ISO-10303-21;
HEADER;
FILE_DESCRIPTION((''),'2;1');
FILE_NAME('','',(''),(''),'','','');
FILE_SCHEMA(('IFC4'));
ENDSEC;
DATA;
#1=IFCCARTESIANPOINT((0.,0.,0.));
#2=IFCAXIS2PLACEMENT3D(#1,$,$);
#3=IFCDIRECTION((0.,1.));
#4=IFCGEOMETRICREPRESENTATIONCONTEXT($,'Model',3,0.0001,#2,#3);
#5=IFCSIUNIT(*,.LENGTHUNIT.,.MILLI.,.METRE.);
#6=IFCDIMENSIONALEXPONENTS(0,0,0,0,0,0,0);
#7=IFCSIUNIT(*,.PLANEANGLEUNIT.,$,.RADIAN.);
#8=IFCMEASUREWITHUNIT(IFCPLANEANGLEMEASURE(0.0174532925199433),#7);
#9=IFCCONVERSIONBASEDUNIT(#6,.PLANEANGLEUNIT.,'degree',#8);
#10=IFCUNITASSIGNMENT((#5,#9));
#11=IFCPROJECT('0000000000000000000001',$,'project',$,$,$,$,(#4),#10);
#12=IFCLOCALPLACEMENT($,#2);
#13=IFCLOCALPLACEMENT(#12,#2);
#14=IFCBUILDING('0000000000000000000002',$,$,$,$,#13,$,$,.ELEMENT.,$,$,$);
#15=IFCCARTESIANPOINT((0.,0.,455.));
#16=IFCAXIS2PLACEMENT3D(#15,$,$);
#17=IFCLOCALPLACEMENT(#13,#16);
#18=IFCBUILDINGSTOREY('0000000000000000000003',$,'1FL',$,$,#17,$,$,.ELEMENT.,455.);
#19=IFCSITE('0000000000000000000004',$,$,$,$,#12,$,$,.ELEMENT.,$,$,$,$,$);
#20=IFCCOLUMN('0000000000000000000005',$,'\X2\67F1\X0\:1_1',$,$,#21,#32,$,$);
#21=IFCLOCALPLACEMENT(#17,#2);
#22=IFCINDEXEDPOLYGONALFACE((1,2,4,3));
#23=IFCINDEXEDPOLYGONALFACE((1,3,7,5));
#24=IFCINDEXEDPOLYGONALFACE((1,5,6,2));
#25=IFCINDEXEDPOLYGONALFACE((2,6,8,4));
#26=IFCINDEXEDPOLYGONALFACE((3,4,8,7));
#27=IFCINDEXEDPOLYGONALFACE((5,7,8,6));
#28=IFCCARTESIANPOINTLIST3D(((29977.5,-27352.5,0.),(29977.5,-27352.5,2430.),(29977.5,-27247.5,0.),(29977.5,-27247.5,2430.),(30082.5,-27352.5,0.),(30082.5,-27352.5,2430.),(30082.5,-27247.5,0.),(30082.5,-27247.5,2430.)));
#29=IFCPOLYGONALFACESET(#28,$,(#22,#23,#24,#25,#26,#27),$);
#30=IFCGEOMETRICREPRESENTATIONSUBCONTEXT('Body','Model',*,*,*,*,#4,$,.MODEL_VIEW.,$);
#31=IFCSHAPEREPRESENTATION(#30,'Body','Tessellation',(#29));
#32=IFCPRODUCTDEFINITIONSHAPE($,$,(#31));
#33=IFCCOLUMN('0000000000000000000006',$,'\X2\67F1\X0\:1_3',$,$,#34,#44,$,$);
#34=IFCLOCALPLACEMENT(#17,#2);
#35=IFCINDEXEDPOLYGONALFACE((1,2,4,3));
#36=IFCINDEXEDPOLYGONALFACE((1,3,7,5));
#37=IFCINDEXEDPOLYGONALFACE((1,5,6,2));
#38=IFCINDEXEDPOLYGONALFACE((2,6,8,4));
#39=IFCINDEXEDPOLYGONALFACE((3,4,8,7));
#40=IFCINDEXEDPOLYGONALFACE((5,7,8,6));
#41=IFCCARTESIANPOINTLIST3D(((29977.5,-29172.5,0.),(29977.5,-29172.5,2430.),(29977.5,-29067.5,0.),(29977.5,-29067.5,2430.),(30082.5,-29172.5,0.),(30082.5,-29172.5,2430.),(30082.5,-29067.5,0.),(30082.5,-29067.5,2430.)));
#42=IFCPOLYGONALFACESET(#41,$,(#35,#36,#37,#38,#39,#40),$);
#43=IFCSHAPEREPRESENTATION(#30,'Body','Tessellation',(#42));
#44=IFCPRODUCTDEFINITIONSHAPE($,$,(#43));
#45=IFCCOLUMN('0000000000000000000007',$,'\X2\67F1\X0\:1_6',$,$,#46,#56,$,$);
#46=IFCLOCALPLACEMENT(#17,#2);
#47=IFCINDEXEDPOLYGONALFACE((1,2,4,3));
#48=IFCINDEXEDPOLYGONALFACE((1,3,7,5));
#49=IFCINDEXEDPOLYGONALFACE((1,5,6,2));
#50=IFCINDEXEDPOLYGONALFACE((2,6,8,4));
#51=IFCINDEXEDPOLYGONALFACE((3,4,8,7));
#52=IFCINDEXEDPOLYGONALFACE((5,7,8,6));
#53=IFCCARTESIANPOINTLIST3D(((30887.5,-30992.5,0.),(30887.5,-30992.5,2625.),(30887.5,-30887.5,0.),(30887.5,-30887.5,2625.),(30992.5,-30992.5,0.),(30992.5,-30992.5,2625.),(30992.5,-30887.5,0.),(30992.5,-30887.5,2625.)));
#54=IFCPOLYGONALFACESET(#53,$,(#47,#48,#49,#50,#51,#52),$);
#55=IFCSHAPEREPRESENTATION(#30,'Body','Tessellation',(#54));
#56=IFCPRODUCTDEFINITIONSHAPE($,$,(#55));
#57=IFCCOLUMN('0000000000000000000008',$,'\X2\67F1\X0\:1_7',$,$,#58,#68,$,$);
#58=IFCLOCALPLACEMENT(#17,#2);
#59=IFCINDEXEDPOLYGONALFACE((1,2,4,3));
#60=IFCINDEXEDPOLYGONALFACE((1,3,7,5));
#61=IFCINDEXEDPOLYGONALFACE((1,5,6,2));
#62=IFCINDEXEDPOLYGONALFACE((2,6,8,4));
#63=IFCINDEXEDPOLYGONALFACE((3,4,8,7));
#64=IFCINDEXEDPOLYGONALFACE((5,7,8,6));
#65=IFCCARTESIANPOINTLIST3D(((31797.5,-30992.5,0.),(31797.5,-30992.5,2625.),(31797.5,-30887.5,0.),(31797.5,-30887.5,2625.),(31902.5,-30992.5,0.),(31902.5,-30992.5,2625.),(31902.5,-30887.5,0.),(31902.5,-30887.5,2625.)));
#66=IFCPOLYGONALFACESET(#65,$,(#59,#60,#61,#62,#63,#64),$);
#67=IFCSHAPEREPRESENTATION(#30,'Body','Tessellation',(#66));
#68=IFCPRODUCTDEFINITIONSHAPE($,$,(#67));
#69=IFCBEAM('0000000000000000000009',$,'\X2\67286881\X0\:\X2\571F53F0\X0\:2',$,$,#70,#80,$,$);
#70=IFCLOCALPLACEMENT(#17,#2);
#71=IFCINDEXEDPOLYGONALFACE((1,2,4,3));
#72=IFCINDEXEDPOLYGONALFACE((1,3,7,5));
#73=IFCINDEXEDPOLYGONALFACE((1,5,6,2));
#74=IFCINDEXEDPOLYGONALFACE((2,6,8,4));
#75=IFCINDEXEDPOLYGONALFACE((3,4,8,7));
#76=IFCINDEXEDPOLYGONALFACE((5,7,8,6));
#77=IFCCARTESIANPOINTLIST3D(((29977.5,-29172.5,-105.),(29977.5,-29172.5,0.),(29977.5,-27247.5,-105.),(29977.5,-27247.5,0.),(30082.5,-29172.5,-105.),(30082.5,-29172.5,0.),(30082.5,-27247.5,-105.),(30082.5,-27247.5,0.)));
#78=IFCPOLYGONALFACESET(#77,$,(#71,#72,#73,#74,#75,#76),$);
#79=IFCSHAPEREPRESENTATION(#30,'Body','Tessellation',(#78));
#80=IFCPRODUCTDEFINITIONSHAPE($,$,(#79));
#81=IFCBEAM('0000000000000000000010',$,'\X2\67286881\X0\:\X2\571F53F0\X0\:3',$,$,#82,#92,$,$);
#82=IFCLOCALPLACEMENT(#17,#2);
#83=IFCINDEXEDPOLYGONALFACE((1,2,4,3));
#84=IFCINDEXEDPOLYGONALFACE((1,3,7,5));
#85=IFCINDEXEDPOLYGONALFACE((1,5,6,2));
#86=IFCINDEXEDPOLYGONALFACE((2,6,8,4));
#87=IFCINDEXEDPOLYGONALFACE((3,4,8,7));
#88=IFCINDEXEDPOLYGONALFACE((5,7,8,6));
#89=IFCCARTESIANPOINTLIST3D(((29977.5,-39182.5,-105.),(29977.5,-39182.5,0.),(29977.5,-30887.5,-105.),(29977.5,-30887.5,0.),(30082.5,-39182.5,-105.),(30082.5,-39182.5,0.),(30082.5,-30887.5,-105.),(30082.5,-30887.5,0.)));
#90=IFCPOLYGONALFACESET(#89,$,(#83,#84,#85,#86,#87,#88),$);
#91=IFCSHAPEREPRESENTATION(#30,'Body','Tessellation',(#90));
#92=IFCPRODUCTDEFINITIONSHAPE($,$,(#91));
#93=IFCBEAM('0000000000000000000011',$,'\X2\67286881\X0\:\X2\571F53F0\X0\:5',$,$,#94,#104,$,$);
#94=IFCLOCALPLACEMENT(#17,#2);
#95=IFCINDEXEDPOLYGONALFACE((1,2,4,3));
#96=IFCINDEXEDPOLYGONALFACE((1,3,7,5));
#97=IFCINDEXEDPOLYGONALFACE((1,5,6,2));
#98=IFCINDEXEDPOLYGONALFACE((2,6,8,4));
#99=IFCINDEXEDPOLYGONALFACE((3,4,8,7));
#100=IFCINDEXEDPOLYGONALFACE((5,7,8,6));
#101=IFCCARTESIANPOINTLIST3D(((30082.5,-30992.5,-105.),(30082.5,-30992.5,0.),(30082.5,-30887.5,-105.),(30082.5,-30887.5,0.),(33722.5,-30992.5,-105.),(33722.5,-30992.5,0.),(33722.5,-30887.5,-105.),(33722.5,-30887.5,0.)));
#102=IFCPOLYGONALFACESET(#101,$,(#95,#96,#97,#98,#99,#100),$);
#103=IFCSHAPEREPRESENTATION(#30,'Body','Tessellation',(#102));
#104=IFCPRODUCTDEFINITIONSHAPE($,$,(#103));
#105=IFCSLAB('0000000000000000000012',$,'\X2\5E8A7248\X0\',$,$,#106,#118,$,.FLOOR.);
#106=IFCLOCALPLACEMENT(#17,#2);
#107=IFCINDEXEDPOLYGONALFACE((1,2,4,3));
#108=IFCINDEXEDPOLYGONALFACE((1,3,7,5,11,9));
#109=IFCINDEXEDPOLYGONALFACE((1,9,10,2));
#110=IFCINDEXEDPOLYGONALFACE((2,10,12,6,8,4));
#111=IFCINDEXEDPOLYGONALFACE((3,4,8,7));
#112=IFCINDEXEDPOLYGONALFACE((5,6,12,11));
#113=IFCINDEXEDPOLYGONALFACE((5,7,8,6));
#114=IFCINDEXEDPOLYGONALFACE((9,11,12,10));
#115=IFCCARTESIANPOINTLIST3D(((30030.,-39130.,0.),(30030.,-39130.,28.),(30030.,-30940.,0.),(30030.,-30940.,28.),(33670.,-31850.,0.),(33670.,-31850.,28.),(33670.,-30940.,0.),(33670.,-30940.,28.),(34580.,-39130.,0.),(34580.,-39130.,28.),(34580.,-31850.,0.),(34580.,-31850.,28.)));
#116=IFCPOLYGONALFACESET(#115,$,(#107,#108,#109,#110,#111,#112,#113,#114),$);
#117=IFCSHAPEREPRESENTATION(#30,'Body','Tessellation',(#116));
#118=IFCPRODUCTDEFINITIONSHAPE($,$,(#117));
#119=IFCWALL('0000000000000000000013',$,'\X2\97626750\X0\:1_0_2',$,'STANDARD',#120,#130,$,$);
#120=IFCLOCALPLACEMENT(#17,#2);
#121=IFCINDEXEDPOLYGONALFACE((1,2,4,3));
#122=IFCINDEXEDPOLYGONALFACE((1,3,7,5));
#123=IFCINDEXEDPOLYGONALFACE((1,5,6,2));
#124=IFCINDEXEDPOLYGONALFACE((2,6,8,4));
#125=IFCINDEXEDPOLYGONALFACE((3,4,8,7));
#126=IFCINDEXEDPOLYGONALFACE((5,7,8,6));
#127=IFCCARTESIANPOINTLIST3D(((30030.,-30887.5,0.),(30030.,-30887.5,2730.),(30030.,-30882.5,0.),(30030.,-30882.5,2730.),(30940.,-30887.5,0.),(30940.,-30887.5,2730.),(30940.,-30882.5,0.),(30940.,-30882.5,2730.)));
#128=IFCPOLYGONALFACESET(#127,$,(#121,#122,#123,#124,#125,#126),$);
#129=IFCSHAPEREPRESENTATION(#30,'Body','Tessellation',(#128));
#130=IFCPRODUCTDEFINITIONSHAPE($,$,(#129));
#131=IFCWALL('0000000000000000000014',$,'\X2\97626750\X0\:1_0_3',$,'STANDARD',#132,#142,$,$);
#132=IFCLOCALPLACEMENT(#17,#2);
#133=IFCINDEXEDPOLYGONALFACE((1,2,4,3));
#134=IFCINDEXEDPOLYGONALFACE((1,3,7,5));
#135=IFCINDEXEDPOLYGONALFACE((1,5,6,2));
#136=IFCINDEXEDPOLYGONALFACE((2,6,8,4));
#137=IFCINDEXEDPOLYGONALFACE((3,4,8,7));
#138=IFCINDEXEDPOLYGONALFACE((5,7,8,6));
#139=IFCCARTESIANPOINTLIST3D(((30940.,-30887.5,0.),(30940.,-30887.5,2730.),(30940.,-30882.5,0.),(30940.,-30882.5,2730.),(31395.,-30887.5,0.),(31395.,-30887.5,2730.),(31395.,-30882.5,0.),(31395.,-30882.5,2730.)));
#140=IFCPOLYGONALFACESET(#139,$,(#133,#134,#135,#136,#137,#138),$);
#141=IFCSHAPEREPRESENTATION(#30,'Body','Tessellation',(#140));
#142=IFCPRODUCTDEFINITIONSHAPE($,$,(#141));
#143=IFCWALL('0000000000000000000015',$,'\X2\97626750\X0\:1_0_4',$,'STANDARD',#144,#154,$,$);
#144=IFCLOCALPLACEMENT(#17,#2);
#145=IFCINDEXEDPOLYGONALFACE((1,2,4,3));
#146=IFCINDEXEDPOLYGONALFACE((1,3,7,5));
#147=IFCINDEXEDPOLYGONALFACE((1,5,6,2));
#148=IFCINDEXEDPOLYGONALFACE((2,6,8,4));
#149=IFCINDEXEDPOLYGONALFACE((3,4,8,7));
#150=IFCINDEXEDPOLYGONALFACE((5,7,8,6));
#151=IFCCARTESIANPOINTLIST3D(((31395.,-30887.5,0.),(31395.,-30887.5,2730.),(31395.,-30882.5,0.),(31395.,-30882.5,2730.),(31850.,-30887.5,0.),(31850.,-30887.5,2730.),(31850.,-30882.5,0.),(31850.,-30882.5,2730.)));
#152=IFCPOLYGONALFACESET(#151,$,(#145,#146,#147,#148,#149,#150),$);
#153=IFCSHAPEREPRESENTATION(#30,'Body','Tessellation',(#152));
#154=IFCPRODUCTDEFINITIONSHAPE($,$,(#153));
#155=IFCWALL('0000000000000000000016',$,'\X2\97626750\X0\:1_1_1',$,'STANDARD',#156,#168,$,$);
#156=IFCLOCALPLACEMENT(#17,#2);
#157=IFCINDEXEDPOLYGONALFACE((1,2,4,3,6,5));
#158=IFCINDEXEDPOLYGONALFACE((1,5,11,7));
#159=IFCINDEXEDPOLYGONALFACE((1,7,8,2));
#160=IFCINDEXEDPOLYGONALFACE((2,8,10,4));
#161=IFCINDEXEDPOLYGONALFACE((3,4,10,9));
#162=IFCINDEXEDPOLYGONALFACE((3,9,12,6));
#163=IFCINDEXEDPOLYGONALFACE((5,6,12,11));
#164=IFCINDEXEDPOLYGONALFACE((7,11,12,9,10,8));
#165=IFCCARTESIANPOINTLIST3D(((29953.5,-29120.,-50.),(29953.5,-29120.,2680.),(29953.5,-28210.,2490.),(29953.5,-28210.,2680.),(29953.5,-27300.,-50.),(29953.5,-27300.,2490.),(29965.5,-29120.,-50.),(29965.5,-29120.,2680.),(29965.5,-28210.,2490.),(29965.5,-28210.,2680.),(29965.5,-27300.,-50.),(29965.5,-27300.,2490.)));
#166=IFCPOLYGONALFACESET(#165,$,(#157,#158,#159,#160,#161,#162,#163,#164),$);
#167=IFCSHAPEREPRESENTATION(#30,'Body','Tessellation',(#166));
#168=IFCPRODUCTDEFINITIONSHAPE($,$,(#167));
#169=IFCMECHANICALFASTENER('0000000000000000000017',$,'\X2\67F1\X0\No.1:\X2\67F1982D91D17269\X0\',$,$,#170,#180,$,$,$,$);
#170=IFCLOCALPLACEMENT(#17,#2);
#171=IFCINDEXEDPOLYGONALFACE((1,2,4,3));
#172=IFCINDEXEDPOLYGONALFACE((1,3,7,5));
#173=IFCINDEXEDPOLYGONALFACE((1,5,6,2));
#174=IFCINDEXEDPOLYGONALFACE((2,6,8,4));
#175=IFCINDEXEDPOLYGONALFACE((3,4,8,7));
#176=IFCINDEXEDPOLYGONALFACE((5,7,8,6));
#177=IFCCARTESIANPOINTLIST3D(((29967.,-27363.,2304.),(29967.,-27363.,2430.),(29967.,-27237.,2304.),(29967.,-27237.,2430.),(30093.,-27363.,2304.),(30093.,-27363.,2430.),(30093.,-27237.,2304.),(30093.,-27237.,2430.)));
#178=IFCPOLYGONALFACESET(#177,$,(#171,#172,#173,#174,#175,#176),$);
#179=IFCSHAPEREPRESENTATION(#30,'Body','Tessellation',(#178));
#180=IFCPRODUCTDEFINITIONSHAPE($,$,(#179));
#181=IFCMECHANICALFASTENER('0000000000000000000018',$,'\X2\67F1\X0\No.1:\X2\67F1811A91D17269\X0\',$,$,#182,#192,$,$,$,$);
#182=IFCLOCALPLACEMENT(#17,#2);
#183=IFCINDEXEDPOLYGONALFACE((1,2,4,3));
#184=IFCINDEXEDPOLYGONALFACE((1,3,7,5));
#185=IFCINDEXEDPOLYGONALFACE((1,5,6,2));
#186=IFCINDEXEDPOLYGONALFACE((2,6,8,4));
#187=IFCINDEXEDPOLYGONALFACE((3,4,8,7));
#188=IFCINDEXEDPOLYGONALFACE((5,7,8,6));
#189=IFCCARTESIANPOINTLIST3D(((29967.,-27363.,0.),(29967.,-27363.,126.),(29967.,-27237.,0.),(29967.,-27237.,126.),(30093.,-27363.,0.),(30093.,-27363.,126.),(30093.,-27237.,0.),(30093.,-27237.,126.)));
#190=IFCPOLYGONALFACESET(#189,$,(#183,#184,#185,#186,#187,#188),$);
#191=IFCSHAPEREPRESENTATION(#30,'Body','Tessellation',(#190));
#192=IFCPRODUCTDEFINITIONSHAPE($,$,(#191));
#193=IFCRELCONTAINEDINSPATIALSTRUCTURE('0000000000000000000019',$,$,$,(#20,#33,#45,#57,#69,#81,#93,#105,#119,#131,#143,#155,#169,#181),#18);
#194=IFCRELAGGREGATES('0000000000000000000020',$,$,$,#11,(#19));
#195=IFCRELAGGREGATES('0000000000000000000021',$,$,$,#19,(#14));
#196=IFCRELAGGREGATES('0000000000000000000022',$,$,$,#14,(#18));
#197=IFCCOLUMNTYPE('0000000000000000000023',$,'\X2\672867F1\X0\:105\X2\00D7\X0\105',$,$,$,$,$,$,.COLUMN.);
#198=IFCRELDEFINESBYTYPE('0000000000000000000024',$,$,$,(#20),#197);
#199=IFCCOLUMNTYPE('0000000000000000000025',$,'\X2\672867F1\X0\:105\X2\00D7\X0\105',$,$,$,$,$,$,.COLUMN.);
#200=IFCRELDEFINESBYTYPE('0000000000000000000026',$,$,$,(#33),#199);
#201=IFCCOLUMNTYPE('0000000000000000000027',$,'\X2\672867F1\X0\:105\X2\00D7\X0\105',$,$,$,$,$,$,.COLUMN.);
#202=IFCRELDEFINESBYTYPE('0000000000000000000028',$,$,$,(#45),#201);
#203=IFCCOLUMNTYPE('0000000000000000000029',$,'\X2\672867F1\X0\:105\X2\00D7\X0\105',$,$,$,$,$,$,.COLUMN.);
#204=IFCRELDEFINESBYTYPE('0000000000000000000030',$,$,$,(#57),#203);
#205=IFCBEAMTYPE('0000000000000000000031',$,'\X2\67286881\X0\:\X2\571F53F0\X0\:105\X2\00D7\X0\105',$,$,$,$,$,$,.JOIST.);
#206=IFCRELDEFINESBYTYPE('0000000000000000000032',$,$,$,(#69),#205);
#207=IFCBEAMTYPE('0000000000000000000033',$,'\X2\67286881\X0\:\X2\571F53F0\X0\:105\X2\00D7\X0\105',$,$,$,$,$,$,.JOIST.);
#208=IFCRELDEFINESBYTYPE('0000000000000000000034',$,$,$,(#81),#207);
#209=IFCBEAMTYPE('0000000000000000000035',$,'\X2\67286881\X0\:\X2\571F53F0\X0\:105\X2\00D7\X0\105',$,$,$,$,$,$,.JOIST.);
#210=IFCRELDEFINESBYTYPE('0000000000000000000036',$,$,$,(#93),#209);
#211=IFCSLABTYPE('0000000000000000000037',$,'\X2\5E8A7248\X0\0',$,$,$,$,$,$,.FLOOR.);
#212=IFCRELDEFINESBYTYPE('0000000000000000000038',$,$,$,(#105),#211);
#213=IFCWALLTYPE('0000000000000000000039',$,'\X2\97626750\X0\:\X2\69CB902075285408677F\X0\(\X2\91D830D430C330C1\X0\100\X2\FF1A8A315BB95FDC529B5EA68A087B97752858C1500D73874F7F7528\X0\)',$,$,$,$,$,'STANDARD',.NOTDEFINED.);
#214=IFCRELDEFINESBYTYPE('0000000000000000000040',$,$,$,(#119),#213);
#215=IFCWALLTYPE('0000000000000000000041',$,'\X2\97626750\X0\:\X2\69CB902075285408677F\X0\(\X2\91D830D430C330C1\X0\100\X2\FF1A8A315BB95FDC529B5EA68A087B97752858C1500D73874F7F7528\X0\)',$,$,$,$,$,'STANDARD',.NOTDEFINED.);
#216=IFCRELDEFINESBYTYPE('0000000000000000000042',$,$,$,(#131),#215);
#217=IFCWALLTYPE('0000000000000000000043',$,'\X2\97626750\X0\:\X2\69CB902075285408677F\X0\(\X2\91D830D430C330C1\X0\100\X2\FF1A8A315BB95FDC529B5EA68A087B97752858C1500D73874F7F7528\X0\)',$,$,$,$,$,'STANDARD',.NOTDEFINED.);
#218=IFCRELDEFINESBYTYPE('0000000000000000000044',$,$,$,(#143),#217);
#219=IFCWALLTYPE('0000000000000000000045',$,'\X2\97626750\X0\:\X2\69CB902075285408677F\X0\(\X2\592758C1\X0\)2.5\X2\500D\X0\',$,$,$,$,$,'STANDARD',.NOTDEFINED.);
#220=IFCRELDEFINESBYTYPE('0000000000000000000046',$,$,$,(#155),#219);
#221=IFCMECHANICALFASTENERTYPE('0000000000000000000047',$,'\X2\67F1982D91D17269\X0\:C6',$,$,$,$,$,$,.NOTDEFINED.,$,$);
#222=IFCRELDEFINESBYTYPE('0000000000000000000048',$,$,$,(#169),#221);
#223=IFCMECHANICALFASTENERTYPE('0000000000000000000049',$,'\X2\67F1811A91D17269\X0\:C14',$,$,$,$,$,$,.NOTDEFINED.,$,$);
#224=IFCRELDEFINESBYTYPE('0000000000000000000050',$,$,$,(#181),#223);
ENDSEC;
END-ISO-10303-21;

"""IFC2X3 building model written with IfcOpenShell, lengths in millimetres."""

from ifc_helpers import new_model, entity, si_unit, converted_unit, direction, frame, origin, origin_with_axes, origin_2d, place, context, subcontext, project, spatial, polyline, rectangle, outline, extrude, type_object, element, save


model = new_model("IFC2X3")

# Units and contexts
model_context = context("Model", 3, precision=0.0001, world=origin(), true_north=direction((0.0, 1.0)))
body_context = subcontext(model_context, "Body", "Model", "MODEL_VIEW")
ifc_project = project(units=[si_unit("LENGTHUNIT", "METRE", prefix="MILLI"), converted_unit("PLANEANGLEUNIT", "degree", entity("IfcPlaneAngleMeasure", 0.0174532925199433), si_unit("PLANEANGLEUNIT", "RADIAN"), dimensions=[0, 0, 0, 0, 0, 0, 0])], contexts=[model_context])

# Site, building, storey
site_placement = place(None, origin())
site = spatial("IfcSite", under=ifc_project, at=site_placement, CompositionType="ELEMENT")
building_placement = place(site_placement, origin())
building = spatial("IfcBuilding", under=site, at=building_placement, CompositionType="ELEMENT")
storey_placement = place(building_placement, frame((0.0, 0.0, 455.0)))
storey = spatial("IfcBuildingStorey", under=building, at=storey_placement, Name="1FL", CompositionType="ELEMENT", Elevation=455.0)

# Columns
column_type_1 = type_object("IfcColumnType", Name="木柱:105×105", PredefinedType="COLUMN")
column_1_placement = place(storey_placement, frame((30030.0, -27300.0, 0.0)))
element("IfcColumn", 1, at=column_1_placement, inside=storey, type_object=column_type_1, Name="柱:1_1", context=body_context, shape_type="SweptSolid", body=[
    extrude(rectangle(XDim=105.0, YDim=105.0, at=origin_2d()), origin_with_axes(), (0.0, 0.0, 1.0), 2430.0),
])
column_type_2 = type_object("IfcColumnType", Name="木柱:105×105", PredefinedType="COLUMN")
column_2_placement = place(storey_placement, frame((30030.0, -29120.0, 0.0)))
element("IfcColumn", 2, at=column_2_placement, inside=storey, type_object=column_type_2, Name="柱:1_3", context=body_context, shape_type="SweptSolid", body=[
    extrude(rectangle(XDim=105.0, YDim=105.0, at=origin_2d()), origin_with_axes(), (0.0, 0.0, 1.0), 2430.0),
])
column_type_3 = type_object("IfcColumnType", Name="木柱:105×105", PredefinedType="COLUMN")
column_3_placement = place(storey_placement, frame((30940.0, -30940.0, 0.0)))
element("IfcColumn", 3, at=column_3_placement, inside=storey, type_object=column_type_3, Name="柱:1_6", context=body_context, shape_type="SweptSolid", body=[
    extrude(rectangle(XDim=105.0, YDim=105.0, at=origin_2d()), origin_with_axes(), (0.0, 0.0, 1.0), 2625.0),
])
column_type_4 = type_object("IfcColumnType", Name="木柱:105×105", PredefinedType="COLUMN")
column_4_placement = place(storey_placement, frame((31850.0, -30940.0, 0.0)))
element("IfcColumn", 4, at=column_4_placement, inside=storey, type_object=column_type_4, Name="柱:1_7", context=body_context, shape_type="SweptSolid", body=[
    extrude(rectangle(XDim=105.0, YDim=105.0, at=origin_2d()), origin_with_axes(), (0.0, 0.0, 1.0), 2625.0),
])

# Beams
beam_type_1 = type_object("IfcBeamType", Name="木梁:土台:105×105", PredefinedType="JOIST")
beam_1_placement = place(storey_placement, frame((30030.0, -27247.5, -52.5), z_axis=(0.0, -1.0, 0.0), x_axis=(1.0, 0.0, 0.0)))
element("IfcBeam", 5, at=beam_1_placement, inside=storey, type_object=beam_type_1, Name="木梁:土台:2", context=body_context, shape_type="SweptSolid", body=[
    extrude(rectangle(XDim=105.0, YDim=105.0, at=origin_2d()), origin_with_axes(), (0.0, 0.0, 1.0), 1925.0),
])
beam_type_2 = type_object("IfcBeamType", Name="木梁:土台:105×105", PredefinedType="JOIST")
beam_2_placement = place(storey_placement, frame((30030.0, -30887.5, -52.5), z_axis=(0.0, -1.0, 0.0), x_axis=(1.0, 0.0, 0.0)))
element("IfcBeam", 6, at=beam_2_placement, inside=storey, type_object=beam_type_2, Name="木梁:土台:3", context=body_context, shape_type="SweptSolid", body=[
    extrude(rectangle(XDim=105.0, YDim=105.0, at=origin_2d()), origin_with_axes(), (0.0, 0.0, 1.0), 8295.0),
])
beam_type_3 = type_object("IfcBeamType", Name="木梁:土台:105×105", PredefinedType="JOIST")
beam_3_placement = place(storey_placement, frame((30082.5, -30940.0, -52.5), z_axis=(1.0, 0.0, 0.0), x_axis=(0.0, 1.0, 0.0)))
element("IfcBeam", 7, at=beam_3_placement, inside=storey, type_object=beam_type_3, Name="木梁:土台:5", context=body_context, shape_type="SweptSolid", body=[
    extrude(rectangle(XDim=105.0, YDim=105.0, at=origin_2d()), origin_with_axes(), (0.0, 0.0, 1.0), 3640.0),
])

# Slab
slab_type = type_object("IfcSlabType", Name="床版0", PredefinedType="FLOOR")
slab_placement = place(storey_placement, origin_with_axes())
element("IfcSlab", 8, at=slab_placement, inside=storey, type_object=slab_type, Name="床版", PredefinedType="FLOOR", context=body_context, shape_type="SweptSolid", body=[
    extrude(outline(polyline([(34580.0, -31850.0, 0.0), (33670.0, -31850.0, 0.0), (33670.0, -30940.0, 0.0), (30030.0, -30940.0, 0.0), (30030.0, -39130.0, 0.0), (34580.0, -39130.0, 0.0), (34580.0, -31850.0, 0.0)])), origin_with_axes(), (0.0, 0.0, 1.0), 28.0),
])

# Walls
wall_type_1 = type_object("IfcWallType", Name="面材:構造用合板(釘ピッチ100：許容応力度計算用壁倍率使用)", ElementType="STANDARD", PredefinedType="NOTDEFINED")
wall_1_placement = place(storey_placement, frame((30485.0, -30882.5, 0.0), z_axis=(0.0, -1.0, 0.0), x_axis=(1.0, 0.0, 0.0)))
element("IfcWall", 9, at=wall_1_placement, inside=storey, type_object=wall_type_1, Name="面材:1_0_2", ObjectType="STANDARD", context=body_context, shape_type="SweptSolid", body=[
    extrude(outline(polyline([(455.0, 0.0, 0.0), (-455.0, 0.0, 0.0), (-455.0, 2730.0, 0.0), (455.0, 2730.0, 0.0), (455.0, 0.0, 0.0)])), origin_with_axes(), (0.0, 0.0, 1.0), 5.0),
])
wall_type_2 = type_object("IfcWallType", Name="面材:構造用合板(釘ピッチ100：許容応力度計算用壁倍率使用)", ElementType="STANDARD", PredefinedType="NOTDEFINED")
wall_2_placement = place(storey_placement, frame((31167.5, -30882.5, 0.0), z_axis=(0.0, -1.0, 0.0), x_axis=(1.0, 0.0, 0.0)))
element("IfcWall", 10, at=wall_2_placement, inside=storey, type_object=wall_type_2, Name="面材:1_0_3", ObjectType="STANDARD", context=body_context, shape_type="SweptSolid", body=[
    extrude(outline(polyline([(227.5, 0.0, 0.0), (-227.5, 0.0, 0.0), (-227.5, 2730.0, 0.0), (227.5, 2730.0, 0.0), (227.5, 0.0, 0.0)])), origin_with_axes(), (0.0, 0.0, 1.0), 5.0),
])
wall_type_3 = type_object("IfcWallType", Name="面材:構造用合板(釘ピッチ100：許容応力度計算用壁倍率使用)", ElementType="STANDARD", PredefinedType="NOTDEFINED")
wall_3_placement = place(storey_placement, frame((31622.5, -30882.5, 0.0), z_axis=(0.0, -1.0, 0.0), x_axis=(1.0, 0.0, 0.0)))
element("IfcWall", 11, at=wall_3_placement, inside=storey, type_object=wall_type_3, Name="面材:1_0_4", ObjectType="STANDARD", context=body_context, shape_type="SweptSolid", body=[
    extrude(outline(polyline([(227.5, 0.0, 0.0), (-227.5, 0.0, 0.0), (-227.5, 2730.0, 0.0), (227.5, 2730.0, 0.0), (227.5, 0.0, 0.0)])), origin_with_axes(), (0.0, 0.0, 1.0), 5.0),
])
wall_type_4 = type_object("IfcWallType", Name="面材:構造用合板(大壁)2.5倍", ElementType="STANDARD", PredefinedType="NOTDEFINED")
wall_4_placement = place(storey_placement, frame((29965.5, -28210.0, -50.0), z_axis=(-1.0, 0.0, 0.0), x_axis=(0.0, -1.0, 0.0)))
element("IfcWall", 12, at=wall_4_placement, inside=storey, type_object=wall_type_4, Name="面材:1_1_1", ObjectType="STANDARD", context=body_context, shape_type="SweptSolid", body=[
    extrude(outline(polyline([(910.0, 0.0, 0.0), (-910.0, 0.0, 0.0), (-910.0, 2540.0, 0.0), (0.0, 2540.0, 0.0), (0.0, 2730.0, 0.0), (910.0, 2730.0, 0.0), (910.0, 0.0, 0.0)])), origin_with_axes(), (0.0, 0.0, 1.0), 12.0),
])

# Mechanical fasteners
mechanical_fastener_type_1 = type_object("IfcMechanicalFastenerType", Name="柱頭金物:C6")
mechanical_fastener_1_placement = place(storey_placement, frame((30030.0, -27300.0, 2304.0)))
element("IfcMechanicalFastener", 13, at=mechanical_fastener_1_placement, inside=storey, type_object=mechanical_fastener_type_1, Name="柱No.1:柱頭金物", context=body_context, shape_type="SweptSolid", body=[
    extrude(rectangle(XDim=126.0, YDim=126.0, at=origin_2d()), origin_with_axes(), (0.0, 0.0, 1.0), 126.0),
])
mechanical_fastener_type_2 = type_object("IfcMechanicalFastenerType", Name="柱脚金物:C14")
mechanical_fastener_2_placement = place(storey_placement, frame((30030.0, -27300.0, 0.0)))
element("IfcMechanicalFastener", 14, at=mechanical_fastener_2_placement, inside=storey, type_object=mechanical_fastener_type_2, Name="柱No.1:柱脚金物", context=body_context, shape_type="SweptSolid", body=[
    extrude(rectangle(XDim=126.0, YDim=126.0, at=origin_2d()), origin_with_axes(), (0.0, 0.0, 1.0), 126.0),
])

save(model, "model.ifc")
